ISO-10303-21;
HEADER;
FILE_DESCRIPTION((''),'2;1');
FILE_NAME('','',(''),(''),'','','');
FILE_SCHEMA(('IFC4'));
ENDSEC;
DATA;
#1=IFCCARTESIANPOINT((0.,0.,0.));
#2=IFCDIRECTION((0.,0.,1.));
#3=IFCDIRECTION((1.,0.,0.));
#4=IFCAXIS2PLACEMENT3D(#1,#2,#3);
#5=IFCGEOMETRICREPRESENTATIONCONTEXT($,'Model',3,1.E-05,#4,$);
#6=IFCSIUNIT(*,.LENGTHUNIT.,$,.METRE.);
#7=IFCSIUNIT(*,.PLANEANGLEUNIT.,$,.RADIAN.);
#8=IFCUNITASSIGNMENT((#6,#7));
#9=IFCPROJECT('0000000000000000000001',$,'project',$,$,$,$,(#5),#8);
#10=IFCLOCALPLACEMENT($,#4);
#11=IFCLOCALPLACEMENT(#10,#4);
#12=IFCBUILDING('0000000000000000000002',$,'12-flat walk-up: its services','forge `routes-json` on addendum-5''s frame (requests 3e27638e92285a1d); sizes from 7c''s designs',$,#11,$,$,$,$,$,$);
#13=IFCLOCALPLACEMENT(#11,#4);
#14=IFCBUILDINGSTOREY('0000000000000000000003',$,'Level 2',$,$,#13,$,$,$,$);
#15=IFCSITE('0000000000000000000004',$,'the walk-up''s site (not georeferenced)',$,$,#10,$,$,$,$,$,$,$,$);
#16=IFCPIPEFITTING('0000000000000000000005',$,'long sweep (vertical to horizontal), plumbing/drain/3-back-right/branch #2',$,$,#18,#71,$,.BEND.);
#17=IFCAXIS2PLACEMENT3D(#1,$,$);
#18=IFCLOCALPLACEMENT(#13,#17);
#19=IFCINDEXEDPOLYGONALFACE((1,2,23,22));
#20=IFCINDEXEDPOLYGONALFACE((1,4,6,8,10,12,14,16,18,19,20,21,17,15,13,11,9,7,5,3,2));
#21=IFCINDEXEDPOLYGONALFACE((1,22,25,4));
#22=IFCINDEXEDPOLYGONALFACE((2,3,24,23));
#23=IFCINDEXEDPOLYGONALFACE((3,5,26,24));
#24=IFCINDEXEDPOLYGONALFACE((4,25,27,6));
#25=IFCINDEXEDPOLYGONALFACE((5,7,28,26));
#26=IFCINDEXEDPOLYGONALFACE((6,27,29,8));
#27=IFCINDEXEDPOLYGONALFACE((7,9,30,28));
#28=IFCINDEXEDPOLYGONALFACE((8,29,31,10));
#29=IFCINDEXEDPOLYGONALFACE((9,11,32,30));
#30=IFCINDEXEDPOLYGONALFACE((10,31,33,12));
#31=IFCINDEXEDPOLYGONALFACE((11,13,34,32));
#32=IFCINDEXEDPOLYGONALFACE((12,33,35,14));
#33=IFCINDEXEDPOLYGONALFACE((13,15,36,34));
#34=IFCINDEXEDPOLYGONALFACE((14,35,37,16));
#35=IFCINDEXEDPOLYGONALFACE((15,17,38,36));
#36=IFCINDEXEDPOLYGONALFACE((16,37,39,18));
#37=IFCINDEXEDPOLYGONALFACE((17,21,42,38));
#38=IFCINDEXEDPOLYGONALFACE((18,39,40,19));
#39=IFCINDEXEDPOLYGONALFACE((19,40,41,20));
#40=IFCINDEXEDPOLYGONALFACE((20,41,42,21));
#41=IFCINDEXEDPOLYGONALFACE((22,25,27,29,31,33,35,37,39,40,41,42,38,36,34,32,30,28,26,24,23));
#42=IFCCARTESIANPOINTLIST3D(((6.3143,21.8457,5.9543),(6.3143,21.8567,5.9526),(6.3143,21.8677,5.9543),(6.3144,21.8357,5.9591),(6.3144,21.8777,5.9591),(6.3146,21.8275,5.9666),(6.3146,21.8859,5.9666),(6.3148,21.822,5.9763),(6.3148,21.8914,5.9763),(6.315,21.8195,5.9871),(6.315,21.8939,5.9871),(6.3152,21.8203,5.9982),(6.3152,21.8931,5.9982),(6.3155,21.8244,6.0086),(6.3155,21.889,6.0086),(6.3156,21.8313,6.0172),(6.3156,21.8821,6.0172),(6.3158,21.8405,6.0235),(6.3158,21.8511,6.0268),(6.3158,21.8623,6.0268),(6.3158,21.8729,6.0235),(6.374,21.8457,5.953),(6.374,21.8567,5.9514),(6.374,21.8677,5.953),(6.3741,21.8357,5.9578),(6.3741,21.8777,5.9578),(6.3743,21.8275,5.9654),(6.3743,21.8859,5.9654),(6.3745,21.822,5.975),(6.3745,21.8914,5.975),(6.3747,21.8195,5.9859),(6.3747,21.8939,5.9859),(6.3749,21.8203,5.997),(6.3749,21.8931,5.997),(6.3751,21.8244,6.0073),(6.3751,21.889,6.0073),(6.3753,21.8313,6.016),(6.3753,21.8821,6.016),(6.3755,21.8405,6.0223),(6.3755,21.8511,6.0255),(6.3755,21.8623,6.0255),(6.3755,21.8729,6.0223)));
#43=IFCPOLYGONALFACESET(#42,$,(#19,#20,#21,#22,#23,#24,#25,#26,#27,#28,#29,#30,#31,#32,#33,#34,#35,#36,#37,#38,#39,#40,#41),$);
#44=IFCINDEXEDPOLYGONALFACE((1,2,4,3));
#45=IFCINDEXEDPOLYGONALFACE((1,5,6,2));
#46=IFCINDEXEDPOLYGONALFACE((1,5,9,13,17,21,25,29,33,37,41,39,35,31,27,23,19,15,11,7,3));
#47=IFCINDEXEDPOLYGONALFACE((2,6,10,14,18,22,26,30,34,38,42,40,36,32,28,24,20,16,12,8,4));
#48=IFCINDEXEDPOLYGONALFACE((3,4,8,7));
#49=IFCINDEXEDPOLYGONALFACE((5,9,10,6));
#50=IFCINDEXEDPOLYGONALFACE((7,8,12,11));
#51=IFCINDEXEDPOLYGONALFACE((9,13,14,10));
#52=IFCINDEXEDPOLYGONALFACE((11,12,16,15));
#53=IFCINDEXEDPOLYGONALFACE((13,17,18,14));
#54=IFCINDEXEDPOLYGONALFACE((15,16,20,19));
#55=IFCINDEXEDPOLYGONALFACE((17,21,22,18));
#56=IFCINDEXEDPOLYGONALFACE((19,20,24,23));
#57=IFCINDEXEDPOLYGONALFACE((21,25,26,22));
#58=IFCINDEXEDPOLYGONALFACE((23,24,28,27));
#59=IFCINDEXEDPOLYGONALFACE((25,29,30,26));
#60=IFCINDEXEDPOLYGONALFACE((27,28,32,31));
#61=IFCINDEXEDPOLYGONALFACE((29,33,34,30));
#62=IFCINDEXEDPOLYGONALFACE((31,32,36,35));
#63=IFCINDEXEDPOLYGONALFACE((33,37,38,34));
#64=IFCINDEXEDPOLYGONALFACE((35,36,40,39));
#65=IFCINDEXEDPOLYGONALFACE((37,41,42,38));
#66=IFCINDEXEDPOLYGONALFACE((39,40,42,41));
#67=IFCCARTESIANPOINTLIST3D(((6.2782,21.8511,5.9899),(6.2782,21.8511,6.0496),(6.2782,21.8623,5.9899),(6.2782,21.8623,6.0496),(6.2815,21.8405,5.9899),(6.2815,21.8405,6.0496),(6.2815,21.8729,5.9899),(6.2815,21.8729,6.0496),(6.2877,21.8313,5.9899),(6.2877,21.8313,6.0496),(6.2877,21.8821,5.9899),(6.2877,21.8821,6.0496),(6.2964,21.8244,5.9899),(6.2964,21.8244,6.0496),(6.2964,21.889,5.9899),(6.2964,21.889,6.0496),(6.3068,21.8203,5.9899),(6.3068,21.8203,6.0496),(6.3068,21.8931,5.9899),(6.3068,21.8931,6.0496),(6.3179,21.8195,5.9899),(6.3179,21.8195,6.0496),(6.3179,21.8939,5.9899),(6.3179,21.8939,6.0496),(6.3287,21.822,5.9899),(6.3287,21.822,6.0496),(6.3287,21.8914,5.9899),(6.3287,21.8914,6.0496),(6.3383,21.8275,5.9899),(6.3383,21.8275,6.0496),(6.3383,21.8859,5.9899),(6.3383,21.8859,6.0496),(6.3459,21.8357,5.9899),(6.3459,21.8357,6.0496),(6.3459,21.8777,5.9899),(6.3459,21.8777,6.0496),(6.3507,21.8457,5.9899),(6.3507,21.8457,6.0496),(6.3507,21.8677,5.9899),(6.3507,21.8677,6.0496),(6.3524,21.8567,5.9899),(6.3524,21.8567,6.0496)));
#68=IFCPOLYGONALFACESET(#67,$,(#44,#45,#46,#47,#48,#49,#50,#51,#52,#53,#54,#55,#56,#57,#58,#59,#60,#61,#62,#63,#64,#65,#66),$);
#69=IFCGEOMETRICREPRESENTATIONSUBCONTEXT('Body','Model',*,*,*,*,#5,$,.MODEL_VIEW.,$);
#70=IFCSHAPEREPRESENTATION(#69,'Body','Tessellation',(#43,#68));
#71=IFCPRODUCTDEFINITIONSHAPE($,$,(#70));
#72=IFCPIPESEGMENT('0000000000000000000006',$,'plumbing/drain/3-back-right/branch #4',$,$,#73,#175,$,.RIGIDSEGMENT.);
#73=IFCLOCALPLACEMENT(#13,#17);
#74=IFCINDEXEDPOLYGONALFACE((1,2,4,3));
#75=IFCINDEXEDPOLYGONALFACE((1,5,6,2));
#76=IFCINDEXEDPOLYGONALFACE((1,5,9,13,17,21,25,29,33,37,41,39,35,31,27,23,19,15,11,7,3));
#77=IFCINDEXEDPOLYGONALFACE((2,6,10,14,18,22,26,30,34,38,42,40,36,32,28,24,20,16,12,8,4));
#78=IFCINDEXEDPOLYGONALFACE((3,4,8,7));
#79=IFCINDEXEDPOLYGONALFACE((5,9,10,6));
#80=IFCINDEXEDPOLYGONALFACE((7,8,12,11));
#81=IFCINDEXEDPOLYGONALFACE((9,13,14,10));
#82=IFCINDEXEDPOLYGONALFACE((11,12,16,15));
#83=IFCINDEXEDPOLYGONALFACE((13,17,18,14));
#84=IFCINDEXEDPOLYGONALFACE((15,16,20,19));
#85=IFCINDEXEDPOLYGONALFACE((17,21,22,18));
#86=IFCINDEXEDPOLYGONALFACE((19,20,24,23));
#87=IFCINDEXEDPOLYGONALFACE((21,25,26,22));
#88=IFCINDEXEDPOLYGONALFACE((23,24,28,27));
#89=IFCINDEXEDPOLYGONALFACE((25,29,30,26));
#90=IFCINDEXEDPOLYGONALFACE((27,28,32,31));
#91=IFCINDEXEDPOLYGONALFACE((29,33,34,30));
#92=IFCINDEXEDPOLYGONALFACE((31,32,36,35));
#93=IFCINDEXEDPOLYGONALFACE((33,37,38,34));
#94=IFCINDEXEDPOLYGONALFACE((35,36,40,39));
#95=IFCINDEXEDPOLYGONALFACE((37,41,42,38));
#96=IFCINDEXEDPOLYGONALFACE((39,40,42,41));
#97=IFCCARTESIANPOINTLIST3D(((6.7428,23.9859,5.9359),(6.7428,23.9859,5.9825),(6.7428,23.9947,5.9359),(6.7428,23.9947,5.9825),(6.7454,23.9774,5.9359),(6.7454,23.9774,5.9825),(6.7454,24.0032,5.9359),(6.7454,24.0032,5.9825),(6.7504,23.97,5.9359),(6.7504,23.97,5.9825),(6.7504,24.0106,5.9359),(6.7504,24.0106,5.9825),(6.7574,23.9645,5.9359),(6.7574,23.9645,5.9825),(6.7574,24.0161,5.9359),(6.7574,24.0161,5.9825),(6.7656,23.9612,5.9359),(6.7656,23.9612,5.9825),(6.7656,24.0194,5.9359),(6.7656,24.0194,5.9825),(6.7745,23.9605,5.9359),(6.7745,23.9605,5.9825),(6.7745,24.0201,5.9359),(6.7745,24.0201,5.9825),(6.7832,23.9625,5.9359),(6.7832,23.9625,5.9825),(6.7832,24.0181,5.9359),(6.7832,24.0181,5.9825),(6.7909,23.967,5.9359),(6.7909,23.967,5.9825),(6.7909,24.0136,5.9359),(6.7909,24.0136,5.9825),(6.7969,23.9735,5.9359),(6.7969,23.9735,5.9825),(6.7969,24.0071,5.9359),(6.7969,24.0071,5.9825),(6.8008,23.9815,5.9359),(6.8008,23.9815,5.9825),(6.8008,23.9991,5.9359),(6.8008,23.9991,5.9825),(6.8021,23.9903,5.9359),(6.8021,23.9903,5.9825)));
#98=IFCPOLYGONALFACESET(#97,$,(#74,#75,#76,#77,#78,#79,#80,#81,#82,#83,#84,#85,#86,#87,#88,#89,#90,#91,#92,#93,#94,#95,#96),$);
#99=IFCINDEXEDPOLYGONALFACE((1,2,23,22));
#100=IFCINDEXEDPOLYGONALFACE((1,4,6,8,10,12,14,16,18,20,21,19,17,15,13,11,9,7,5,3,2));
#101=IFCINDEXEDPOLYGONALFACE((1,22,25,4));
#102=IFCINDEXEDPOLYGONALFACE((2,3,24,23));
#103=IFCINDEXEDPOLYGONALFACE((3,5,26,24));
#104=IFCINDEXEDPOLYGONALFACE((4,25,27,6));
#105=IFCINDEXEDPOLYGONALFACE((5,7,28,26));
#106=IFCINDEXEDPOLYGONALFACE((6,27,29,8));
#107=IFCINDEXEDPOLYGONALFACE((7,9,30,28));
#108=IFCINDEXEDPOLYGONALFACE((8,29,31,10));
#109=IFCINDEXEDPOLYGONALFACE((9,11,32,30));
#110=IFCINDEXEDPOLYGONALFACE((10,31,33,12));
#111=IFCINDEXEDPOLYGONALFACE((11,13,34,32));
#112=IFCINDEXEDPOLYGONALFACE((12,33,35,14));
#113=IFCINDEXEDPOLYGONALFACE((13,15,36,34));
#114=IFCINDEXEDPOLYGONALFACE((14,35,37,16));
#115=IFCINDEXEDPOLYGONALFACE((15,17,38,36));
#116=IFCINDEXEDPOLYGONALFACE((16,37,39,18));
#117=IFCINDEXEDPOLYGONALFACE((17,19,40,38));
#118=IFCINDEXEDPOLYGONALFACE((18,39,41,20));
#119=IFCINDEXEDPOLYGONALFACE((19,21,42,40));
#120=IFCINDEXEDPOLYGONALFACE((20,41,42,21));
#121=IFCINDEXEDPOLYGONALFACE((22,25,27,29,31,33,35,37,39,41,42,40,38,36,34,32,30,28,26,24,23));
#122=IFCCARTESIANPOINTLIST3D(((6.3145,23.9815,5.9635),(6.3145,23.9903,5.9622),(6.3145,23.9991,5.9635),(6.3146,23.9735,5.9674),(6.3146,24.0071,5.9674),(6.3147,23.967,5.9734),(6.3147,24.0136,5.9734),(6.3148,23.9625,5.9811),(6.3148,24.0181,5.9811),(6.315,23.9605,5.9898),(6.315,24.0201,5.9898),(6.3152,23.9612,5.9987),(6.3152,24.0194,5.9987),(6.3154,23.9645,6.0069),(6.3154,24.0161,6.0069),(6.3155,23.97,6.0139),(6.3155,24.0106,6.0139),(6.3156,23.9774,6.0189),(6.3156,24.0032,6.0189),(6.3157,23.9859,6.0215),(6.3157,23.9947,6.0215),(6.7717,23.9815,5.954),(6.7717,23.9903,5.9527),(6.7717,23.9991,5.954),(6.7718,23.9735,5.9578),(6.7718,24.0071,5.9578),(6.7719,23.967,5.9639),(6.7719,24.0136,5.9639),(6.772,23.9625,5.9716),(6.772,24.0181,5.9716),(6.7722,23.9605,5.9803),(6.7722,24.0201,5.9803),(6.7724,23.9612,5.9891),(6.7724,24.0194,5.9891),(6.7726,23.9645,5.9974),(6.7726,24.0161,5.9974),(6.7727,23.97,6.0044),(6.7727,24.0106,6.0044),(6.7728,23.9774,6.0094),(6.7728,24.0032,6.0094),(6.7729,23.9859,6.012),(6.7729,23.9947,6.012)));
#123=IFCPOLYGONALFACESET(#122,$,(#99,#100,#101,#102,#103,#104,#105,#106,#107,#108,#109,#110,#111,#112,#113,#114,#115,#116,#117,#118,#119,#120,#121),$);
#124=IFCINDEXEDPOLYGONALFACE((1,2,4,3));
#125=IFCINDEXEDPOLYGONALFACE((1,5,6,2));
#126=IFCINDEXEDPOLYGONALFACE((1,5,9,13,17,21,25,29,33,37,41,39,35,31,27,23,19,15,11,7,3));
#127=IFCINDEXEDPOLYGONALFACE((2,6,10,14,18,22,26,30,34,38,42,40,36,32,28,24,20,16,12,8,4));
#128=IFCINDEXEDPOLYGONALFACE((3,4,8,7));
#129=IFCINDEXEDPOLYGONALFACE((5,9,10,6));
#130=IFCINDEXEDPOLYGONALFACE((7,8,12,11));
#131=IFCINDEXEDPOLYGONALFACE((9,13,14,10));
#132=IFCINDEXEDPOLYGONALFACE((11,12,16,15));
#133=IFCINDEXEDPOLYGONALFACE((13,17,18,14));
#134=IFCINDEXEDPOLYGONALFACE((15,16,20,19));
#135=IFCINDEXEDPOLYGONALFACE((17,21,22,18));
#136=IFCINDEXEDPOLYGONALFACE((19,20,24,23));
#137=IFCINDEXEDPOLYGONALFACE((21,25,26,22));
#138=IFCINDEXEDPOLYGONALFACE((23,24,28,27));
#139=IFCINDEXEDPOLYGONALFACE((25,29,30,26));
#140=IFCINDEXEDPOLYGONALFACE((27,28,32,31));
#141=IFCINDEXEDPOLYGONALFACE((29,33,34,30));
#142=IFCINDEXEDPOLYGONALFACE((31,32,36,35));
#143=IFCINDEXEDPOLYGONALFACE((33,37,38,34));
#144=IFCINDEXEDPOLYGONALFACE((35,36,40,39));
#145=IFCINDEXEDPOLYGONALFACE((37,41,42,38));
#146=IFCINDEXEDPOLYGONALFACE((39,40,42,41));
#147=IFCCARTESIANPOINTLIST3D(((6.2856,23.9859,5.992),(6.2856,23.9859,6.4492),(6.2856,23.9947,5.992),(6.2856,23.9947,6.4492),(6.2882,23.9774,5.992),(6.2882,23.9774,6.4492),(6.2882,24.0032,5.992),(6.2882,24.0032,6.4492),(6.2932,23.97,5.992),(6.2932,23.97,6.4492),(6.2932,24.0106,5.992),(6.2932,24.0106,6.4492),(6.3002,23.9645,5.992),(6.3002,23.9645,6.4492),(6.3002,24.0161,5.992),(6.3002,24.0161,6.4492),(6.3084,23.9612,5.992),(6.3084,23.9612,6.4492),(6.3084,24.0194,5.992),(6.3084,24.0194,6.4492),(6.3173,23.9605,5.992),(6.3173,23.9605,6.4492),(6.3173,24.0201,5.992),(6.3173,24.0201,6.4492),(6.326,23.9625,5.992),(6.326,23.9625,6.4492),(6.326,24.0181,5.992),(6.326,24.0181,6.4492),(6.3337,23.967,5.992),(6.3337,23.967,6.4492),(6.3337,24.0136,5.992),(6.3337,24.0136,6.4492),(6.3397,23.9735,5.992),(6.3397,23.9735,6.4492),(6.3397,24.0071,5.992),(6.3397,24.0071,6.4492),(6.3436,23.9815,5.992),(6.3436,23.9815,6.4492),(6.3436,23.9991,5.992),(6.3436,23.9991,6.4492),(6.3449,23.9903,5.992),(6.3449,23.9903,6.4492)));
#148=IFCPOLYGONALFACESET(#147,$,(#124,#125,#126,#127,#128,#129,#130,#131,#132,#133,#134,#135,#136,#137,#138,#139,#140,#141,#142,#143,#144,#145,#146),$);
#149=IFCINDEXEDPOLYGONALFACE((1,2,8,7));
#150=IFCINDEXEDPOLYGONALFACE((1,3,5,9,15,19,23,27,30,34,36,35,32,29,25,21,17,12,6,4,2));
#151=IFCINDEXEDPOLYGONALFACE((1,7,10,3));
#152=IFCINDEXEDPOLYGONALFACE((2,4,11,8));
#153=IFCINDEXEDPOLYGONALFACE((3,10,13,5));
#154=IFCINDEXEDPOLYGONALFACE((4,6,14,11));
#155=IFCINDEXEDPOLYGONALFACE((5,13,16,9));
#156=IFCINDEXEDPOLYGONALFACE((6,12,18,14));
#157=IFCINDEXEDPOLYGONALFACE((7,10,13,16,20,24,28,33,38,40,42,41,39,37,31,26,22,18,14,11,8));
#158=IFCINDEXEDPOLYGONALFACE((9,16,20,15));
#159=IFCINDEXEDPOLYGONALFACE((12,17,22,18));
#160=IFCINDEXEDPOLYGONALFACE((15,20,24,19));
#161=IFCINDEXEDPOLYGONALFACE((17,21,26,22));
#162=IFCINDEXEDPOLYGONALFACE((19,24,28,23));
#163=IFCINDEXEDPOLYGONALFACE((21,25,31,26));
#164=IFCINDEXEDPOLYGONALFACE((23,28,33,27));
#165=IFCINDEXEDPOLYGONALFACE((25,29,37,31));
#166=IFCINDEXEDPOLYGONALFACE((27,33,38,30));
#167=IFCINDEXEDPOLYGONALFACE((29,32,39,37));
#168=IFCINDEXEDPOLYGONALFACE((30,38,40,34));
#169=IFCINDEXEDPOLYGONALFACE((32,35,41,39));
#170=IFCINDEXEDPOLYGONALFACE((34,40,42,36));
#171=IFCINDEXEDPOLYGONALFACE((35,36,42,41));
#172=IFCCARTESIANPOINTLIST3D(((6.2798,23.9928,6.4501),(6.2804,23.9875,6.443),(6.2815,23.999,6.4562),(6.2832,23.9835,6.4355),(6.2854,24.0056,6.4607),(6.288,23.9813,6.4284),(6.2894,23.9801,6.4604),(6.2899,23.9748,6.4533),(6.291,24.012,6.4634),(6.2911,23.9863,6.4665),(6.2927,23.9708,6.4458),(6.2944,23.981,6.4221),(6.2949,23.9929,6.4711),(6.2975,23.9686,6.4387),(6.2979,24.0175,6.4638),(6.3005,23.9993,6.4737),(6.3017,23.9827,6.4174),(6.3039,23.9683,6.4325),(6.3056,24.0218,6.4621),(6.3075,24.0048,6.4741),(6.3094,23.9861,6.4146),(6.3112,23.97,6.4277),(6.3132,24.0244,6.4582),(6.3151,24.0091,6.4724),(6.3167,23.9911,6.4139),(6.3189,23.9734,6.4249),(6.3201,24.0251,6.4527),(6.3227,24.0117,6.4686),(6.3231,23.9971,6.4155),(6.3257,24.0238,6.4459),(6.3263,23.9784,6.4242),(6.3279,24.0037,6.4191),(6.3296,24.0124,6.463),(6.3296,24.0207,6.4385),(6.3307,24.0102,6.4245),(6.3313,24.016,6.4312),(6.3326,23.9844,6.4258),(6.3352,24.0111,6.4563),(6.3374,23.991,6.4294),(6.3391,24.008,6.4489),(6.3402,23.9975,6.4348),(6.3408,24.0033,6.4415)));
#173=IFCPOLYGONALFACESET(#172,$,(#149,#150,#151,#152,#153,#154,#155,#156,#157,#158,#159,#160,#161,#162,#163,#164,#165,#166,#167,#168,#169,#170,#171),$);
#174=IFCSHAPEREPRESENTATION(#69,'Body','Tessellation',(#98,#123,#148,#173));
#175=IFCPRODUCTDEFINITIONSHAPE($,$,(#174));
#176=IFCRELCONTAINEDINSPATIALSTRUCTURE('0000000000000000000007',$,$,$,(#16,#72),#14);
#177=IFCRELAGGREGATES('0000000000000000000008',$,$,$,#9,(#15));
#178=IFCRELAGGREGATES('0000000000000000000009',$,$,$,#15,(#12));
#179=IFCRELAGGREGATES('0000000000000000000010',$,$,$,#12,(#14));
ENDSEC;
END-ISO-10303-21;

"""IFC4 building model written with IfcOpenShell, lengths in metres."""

from ifc_helpers import new_model, entity, si_unit, frame, origin_with_axes, place, context, subcontext, project, spatial, element, save


model = new_model("IFC4")

# Units and contexts
model_context = context("Model", 3, precision=1e-05, world=origin_with_axes())
body_context = subcontext(model_context, "Body", "Model", "MODEL_VIEW")
ifc_project = project(units=[si_unit("LENGTHUNIT", "METRE"), si_unit("PLANEANGLEUNIT", "RADIAN")], contexts=[model_context])

# Site, building, storey
site_placement = place(None, origin_with_axes())
site = spatial("IfcSite", under=ifc_project, at=site_placement, Name="the walk-up's site (not georeferenced)")
building_placement = place(site_placement, origin_with_axes())
building = spatial("IfcBuilding", under=site, at=building_placement, Name="12-flat walk-up: its services", Description="forge `routes-json` on addendum-5's frame (requests 3e27638e92285a1d); sizes from 7c's designs")
storey_placement = place(building_placement, origin_with_axes())
storey = spatial("IfcBuildingStorey", under=building, at=storey_placement, Name="Level 2")

# Pipe fitting
pipe_fitting_1_placement = place(storey_placement, frame((6.3748, 21.8567, 5.9887), z_axis=(0.0, 0.0, 1.0), x_axis=(1.0, 0.0, 0.0)))
element("IfcPipeFitting", 1, at=pipe_fitting_1_placement, inside=storey, Name="long sweep (vertical to horizontal), plumbing/drain/3-back-right/branch #2", PredefinedType="BEND", context=body_context, shape_type="AdvancedSweptSolid", body=[
    entity("IfcSweptDiskSolid", entity("IfcPolyline", [entity("IfcCartesianPoint", [0.0, 0.0, 0.0]), entity("IfcCartesianPoint", [-0.0597, 0.0, 0.0012])]), 0.0373),
    entity("IfcSweptDiskSolid", entity("IfcPolyline", [entity("IfcCartesianPoint", [-0.0597, 0.0, 0.0012]), entity("IfcCartesianPoint", [-0.0597, 0.0, 0.0609])]), 0.0373),
])

# Pipe segment
pipe_segment_1_placement = place(storey_placement, frame((6.7723, 23.9903, 5.9359), z_axis=(0.0, 0.0, 1.0), x_axis=(1.0, 0.0, 0.0)))
element("IfcPipeSegment", 2, at=pipe_segment_1_placement, inside=storey, Name="plumbing/drain/3-back-right/branch #4", PredefinedType="RIGIDSEGMENT", context=body_context, shape_type="AdvancedSweptSolid", body=[
    entity("IfcSweptDiskSolid", entity("IfcPolyline", [entity("IfcCartesianPoint", [0.0, 0.0, 0.0]), entity("IfcCartesianPoint", [0.0, 0.0, 0.0466])]), 0.0298),
    entity("IfcSweptDiskSolid", entity("IfcPolyline", [entity("IfcCartesianPoint", [0.0, 0.0, 0.0466]), entity("IfcCartesianPoint", [-0.4572, 0.0, 0.0561])]), 0.0298),
    entity("IfcSweptDiskSolid", entity("IfcPolyline", [entity("IfcCartesianPoint", [-0.4572, 0.0, 0.0561]), entity("IfcCartesianPoint", [-0.4572, 0.0, 0.5133])]), 0.0298),
    entity("IfcSweptDiskSolid", entity("IfcPolyline", [entity("IfcCartesianPoint", [-0.4572, 0.0, 0.5133]), entity("IfcCartesianPoint", [-0.4667, 0.0127, 0.503])]), 0.0298),
])

save(model, "model.ifc")
